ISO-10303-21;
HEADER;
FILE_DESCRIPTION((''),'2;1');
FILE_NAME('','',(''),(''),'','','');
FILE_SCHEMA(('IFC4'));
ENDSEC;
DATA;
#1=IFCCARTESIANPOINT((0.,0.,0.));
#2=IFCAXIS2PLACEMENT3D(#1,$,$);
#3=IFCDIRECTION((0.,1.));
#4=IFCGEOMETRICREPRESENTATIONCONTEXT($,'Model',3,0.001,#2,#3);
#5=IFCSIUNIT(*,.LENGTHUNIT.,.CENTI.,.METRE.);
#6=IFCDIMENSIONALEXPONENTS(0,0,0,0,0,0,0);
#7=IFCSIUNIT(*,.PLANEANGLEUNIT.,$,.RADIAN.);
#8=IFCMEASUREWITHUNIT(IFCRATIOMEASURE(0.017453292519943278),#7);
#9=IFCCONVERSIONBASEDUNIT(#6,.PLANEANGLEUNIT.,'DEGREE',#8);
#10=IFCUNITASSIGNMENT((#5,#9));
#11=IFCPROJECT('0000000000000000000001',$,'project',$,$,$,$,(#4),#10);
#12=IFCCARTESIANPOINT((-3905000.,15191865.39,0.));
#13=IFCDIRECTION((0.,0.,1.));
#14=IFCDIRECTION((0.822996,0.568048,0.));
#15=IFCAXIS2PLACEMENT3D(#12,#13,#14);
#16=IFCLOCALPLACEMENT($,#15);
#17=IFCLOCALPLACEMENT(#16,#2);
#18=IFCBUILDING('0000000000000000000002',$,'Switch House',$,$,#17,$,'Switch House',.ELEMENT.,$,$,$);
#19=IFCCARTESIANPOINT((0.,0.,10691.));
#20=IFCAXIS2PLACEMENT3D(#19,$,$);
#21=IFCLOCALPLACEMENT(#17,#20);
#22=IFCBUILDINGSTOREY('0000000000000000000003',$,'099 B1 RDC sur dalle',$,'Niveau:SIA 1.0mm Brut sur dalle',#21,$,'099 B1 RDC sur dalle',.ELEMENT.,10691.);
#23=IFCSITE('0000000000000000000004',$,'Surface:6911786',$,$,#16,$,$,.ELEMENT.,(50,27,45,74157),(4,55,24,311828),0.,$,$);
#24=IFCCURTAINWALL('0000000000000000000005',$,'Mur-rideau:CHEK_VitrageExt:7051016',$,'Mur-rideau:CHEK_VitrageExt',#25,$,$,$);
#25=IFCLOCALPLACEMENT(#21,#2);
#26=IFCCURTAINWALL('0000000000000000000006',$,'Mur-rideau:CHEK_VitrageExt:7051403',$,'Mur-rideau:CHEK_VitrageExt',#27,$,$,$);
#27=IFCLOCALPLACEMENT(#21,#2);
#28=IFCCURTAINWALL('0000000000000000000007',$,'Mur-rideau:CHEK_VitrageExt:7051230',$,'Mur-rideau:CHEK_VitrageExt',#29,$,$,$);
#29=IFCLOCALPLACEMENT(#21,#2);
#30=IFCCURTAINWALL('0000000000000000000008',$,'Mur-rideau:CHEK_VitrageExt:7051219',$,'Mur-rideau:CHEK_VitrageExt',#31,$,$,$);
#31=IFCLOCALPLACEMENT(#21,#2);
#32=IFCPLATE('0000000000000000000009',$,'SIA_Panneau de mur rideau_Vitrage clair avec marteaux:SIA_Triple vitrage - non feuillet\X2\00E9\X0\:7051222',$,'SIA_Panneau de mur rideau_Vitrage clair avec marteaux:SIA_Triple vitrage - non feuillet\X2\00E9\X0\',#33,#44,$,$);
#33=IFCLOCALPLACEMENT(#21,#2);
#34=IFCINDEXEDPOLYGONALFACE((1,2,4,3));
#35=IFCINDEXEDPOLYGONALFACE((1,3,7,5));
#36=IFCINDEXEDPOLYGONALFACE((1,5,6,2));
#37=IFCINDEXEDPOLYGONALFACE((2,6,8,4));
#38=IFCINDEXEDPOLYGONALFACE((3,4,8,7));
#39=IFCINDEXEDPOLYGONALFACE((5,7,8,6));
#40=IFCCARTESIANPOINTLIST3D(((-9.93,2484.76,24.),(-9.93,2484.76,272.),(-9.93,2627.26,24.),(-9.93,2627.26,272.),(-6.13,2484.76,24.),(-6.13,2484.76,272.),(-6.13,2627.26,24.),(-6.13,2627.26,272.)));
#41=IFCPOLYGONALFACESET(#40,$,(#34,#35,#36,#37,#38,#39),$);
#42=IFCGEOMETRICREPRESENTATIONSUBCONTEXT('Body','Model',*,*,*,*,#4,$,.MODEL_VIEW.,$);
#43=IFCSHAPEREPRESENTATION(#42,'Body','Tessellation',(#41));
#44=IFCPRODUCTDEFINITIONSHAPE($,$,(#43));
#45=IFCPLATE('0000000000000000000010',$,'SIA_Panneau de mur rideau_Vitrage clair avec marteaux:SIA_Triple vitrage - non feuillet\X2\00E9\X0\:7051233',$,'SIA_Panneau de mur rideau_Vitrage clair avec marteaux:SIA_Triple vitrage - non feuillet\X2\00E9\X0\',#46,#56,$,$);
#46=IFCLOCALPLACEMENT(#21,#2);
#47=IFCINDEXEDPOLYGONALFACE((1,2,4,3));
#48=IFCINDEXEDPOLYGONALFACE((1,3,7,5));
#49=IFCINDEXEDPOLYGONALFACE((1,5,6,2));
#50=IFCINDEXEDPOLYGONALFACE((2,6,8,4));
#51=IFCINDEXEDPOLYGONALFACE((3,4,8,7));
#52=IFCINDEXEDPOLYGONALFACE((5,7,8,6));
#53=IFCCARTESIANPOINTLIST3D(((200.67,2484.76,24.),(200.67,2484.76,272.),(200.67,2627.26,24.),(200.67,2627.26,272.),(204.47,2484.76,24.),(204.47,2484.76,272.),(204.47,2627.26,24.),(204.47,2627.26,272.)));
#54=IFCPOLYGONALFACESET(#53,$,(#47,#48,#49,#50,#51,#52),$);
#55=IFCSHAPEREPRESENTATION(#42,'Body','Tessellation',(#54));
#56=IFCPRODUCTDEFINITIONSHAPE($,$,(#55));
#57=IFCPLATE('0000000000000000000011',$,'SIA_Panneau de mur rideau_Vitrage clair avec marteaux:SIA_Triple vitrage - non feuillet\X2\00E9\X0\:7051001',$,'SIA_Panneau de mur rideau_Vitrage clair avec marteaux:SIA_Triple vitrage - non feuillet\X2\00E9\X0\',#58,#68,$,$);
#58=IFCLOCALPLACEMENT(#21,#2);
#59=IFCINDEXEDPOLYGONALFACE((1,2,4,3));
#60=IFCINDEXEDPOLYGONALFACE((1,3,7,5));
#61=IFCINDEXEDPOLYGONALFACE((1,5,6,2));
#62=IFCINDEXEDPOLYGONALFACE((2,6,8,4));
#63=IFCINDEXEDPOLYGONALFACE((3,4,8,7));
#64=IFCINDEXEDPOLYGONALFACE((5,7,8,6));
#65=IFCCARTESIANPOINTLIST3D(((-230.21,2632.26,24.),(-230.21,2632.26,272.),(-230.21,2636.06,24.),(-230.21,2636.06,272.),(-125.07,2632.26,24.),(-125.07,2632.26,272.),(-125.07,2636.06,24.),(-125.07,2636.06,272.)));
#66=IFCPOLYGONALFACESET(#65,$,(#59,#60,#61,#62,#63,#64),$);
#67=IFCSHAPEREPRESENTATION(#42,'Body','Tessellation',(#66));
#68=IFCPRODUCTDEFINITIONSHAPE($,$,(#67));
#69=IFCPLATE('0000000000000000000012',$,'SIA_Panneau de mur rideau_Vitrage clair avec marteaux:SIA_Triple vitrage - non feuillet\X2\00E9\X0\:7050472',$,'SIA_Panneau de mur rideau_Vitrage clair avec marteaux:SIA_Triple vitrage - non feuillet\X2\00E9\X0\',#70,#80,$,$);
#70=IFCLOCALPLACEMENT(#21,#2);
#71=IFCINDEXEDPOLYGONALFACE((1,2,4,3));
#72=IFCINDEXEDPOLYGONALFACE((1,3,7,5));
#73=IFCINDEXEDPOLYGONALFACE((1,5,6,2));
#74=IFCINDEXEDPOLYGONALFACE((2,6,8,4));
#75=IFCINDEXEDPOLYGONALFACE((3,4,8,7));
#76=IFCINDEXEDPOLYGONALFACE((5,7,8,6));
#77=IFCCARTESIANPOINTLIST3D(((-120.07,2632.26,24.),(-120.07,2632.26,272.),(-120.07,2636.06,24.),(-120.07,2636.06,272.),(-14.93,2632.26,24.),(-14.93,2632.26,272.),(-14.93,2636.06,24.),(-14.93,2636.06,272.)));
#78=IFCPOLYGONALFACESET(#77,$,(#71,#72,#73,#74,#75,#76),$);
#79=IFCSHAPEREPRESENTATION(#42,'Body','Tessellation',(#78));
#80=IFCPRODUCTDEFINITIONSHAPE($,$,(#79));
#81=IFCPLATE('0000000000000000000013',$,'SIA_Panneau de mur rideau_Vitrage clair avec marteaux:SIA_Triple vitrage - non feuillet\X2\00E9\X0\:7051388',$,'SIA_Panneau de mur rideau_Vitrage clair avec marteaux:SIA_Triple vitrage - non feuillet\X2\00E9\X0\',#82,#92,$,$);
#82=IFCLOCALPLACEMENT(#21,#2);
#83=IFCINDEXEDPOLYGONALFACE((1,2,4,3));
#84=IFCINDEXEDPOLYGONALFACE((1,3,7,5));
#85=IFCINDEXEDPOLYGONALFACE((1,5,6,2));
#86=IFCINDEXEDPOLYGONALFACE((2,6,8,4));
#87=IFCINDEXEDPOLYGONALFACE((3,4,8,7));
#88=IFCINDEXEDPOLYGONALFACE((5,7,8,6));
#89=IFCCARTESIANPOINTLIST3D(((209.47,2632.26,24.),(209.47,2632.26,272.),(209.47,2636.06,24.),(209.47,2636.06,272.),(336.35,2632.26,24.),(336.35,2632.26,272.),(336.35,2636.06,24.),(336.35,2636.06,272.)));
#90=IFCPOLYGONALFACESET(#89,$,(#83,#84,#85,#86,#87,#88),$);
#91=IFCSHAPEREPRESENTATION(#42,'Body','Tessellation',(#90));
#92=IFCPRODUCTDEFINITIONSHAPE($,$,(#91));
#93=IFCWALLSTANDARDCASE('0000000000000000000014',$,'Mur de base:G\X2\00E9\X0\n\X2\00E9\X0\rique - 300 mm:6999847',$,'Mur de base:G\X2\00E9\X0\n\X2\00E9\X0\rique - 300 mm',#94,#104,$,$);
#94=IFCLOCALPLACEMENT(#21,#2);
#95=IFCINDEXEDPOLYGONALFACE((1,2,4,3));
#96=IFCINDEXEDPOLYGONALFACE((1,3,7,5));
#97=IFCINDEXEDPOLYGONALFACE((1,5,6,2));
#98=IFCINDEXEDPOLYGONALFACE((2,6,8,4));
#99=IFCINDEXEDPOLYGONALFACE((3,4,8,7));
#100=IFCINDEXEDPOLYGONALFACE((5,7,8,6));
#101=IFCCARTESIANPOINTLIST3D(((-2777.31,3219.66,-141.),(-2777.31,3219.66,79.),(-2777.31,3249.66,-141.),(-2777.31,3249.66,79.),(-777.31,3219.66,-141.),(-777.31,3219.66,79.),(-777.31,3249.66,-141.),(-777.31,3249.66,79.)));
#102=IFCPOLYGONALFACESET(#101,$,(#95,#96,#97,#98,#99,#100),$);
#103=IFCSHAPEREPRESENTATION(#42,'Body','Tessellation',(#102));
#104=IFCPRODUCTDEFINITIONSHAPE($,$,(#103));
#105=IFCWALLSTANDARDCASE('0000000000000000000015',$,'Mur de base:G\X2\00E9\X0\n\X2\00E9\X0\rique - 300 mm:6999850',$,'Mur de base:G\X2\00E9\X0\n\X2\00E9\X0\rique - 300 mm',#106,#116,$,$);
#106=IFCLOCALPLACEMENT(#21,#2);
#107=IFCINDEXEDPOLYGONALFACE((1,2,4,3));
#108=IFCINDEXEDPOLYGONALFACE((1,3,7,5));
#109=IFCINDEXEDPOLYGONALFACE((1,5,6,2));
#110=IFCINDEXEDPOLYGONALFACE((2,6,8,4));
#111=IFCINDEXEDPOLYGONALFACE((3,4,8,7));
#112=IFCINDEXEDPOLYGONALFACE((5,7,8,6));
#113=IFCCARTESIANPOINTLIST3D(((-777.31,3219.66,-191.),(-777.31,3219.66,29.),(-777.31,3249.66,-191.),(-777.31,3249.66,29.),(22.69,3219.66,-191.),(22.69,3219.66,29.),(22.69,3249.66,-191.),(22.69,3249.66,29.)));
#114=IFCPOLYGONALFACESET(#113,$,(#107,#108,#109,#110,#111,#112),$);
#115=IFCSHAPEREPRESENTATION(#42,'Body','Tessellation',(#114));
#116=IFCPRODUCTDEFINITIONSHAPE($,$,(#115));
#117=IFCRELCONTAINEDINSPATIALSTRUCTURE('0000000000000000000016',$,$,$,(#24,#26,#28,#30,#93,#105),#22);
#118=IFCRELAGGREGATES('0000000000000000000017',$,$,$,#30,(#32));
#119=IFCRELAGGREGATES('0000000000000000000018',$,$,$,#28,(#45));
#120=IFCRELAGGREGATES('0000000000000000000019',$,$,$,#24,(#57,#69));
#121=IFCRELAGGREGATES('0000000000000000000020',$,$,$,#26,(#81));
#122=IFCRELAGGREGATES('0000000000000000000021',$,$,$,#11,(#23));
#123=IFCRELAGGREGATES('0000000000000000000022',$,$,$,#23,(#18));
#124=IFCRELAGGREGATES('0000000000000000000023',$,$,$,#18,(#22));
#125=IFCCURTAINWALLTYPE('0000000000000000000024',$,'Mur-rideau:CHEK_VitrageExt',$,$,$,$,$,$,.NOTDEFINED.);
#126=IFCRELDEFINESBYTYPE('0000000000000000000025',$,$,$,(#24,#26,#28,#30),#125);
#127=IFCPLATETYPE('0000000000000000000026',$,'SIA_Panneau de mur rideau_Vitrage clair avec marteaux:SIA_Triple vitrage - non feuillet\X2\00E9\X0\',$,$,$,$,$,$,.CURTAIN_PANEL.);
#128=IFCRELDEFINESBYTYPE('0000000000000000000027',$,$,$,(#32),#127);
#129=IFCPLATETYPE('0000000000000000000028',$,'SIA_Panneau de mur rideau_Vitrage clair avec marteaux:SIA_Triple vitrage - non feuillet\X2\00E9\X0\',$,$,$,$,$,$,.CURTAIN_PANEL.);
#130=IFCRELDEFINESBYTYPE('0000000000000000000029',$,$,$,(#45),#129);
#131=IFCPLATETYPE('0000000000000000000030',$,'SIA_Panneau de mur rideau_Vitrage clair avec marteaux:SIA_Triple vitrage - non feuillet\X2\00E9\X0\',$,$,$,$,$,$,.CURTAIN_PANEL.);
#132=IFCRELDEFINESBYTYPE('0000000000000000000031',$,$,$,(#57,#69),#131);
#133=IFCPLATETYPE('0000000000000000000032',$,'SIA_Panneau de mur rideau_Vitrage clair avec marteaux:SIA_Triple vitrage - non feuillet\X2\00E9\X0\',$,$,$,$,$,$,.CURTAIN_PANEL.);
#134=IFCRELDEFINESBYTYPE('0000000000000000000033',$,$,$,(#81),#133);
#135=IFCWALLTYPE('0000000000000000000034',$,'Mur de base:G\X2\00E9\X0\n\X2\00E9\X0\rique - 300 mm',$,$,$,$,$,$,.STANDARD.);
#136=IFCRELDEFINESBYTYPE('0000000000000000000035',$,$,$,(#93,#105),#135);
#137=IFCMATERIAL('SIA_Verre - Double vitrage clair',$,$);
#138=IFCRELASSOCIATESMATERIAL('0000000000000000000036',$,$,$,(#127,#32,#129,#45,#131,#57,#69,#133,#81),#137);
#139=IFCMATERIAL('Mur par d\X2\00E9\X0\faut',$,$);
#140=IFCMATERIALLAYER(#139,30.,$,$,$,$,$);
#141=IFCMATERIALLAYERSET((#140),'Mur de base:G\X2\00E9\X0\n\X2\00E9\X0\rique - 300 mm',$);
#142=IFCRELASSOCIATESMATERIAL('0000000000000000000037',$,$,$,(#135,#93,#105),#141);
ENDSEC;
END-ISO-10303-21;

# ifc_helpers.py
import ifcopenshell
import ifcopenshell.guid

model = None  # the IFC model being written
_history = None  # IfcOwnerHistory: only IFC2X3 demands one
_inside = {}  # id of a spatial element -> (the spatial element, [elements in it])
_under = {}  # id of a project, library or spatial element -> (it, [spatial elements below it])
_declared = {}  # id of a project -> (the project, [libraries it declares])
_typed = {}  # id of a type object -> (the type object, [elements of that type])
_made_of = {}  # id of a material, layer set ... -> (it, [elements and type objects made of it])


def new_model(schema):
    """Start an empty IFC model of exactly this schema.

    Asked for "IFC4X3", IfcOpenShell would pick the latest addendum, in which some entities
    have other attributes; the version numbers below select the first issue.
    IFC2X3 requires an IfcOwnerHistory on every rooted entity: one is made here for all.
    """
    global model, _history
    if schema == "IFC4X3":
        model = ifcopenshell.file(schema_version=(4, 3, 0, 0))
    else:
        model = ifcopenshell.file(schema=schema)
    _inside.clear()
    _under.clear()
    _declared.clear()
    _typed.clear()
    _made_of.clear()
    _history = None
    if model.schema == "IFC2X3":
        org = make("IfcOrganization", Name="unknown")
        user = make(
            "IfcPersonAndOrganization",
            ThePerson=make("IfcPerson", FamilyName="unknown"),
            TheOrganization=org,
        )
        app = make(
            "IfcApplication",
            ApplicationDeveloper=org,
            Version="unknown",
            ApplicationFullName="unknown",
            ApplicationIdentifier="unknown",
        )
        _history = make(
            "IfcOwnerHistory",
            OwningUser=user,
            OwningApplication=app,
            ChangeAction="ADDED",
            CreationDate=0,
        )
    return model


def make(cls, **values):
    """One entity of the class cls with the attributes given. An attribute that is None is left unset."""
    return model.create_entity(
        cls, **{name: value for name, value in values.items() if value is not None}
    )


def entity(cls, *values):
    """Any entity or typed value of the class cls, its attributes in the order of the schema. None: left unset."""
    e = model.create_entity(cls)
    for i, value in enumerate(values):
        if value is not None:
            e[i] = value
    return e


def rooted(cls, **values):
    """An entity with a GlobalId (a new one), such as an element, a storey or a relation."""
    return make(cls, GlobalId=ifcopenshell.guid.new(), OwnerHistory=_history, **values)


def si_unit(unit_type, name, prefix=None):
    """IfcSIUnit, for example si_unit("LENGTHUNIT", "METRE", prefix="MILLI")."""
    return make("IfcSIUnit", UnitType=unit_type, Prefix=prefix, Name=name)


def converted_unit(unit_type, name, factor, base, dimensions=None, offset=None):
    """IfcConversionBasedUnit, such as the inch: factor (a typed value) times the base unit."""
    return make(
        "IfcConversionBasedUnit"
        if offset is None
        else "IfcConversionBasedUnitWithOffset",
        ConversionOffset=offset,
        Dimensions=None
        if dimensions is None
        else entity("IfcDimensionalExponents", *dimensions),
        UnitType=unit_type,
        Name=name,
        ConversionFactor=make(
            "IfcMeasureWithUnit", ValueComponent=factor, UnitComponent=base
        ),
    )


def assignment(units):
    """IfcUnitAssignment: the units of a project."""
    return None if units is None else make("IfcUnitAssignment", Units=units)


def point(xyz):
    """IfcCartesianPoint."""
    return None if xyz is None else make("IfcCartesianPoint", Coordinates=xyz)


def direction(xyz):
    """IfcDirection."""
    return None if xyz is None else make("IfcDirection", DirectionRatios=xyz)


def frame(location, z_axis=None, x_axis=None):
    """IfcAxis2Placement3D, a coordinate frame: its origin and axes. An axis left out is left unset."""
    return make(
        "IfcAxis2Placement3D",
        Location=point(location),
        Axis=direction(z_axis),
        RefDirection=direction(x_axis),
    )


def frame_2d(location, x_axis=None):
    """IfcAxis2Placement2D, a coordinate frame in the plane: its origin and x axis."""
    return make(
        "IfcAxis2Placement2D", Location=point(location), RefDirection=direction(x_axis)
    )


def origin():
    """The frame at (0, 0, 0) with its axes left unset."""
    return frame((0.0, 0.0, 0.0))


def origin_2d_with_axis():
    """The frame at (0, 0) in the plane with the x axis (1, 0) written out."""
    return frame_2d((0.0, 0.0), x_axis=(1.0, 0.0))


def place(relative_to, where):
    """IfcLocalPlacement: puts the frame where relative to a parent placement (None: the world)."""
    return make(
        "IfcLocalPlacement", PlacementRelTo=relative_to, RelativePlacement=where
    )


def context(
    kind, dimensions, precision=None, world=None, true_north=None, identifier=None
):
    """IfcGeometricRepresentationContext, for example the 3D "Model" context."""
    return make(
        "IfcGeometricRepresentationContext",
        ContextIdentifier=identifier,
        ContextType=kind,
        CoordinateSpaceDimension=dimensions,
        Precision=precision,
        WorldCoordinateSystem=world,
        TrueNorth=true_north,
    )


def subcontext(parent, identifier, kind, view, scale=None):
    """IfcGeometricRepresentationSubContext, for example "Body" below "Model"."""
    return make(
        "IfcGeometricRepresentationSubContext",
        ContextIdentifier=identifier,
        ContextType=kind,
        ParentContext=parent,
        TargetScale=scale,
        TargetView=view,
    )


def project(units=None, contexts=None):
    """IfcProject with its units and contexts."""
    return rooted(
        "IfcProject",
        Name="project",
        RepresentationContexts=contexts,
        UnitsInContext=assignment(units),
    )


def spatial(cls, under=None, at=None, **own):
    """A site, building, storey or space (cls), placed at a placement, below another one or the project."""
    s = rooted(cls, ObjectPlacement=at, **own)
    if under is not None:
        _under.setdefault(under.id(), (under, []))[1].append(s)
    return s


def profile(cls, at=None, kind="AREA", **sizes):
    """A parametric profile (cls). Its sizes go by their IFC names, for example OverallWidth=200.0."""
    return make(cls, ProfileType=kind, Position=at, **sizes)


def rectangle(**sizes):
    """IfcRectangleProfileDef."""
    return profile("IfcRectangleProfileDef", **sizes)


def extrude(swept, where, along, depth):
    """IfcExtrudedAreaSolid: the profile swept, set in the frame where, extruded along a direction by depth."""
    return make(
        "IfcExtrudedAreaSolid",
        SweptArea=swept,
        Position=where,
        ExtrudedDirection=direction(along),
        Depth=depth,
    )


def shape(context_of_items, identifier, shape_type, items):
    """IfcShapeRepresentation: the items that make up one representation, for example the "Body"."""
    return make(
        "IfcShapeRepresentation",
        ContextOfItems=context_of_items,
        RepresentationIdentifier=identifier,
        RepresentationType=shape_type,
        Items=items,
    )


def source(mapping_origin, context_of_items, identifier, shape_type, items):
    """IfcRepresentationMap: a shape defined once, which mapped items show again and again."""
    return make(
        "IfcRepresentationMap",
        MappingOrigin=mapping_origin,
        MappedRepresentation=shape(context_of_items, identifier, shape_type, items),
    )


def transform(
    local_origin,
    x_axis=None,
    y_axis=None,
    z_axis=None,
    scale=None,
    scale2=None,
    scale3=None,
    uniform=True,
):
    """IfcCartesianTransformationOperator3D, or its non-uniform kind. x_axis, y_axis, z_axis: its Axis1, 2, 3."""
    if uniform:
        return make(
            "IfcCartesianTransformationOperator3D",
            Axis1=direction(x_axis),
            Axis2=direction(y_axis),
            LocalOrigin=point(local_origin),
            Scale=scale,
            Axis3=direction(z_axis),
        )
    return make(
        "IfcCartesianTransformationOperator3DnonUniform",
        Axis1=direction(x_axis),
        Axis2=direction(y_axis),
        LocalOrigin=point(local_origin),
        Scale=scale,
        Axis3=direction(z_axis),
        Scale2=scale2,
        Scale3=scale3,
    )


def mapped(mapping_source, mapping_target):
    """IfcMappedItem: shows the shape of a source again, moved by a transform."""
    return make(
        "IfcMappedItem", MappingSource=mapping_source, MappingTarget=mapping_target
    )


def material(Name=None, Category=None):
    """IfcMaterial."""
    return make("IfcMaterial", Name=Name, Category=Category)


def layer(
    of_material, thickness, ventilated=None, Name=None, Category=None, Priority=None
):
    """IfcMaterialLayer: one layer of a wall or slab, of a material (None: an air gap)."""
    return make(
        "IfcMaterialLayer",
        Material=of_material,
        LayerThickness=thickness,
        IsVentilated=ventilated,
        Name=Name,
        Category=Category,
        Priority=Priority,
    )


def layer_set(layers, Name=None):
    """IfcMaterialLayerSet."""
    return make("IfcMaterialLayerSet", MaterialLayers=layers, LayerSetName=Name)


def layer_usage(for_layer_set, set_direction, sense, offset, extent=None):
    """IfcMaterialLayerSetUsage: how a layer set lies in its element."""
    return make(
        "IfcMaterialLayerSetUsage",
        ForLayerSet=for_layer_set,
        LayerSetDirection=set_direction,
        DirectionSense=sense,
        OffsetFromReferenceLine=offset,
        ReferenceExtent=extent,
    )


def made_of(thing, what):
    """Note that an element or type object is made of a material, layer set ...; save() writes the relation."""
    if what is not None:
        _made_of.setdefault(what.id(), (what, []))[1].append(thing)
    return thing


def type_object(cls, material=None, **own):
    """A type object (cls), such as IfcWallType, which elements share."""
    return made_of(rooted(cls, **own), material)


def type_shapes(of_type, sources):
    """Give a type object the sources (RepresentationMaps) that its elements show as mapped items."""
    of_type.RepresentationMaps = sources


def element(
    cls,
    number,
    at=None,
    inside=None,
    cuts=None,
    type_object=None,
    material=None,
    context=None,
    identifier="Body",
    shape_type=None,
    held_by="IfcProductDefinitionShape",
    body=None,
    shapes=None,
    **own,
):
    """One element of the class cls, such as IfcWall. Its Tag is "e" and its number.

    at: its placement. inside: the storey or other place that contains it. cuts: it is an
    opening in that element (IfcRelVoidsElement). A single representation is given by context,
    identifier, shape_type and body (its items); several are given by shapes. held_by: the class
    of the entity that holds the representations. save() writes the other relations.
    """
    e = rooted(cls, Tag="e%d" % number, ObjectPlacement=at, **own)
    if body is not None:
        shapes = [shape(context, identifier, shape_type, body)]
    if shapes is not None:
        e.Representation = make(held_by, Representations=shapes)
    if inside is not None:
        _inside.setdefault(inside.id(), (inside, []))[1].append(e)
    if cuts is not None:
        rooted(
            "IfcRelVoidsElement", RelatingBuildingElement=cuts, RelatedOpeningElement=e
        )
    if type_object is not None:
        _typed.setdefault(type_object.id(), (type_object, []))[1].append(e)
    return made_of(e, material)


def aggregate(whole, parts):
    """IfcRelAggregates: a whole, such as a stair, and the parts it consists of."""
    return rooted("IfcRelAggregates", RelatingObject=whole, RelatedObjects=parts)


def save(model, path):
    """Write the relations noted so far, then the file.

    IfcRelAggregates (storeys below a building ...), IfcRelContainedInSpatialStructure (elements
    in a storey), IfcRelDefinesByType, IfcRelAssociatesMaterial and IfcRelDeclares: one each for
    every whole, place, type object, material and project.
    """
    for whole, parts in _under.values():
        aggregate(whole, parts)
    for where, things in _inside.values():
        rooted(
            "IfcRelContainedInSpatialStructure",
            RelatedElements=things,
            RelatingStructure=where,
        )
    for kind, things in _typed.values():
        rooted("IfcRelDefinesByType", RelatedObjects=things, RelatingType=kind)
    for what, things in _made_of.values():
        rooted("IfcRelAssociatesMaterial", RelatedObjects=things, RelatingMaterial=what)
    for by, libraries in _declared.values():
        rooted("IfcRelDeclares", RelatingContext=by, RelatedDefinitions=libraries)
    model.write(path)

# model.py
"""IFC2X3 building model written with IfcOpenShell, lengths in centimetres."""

from ifc_helpers import new_model, entity, si_unit, converted_unit, direction, frame, frame_2d, origin, origin_2d_with_axis, place, context, subcontext, project, spatial, rectangle, extrude, source, transform, mapped, material, layer, layer_set, layer_usage, type_object, type_shapes, element, aggregate, save


model = new_model("IFC2X3")

# Units and contexts
model_context = context("Model", 3, precision=0.001, world=origin(), true_north=direction((0.0, 1.0)))
body_context = subcontext(model_context, "Body", "Model", "MODEL_VIEW")
ifc_project = project(units=[si_unit("LENGTHUNIT", "METRE", prefix="CENTI"), converted_unit("PLANEANGLEUNIT", "DEGREE", entity("IfcRatioMeasure", 0.017453292519943278), si_unit("PLANEANGLEUNIT", "RADIAN"), dimensions=[0, 0, 0, 0, 0, 0, 0])], contexts=[model_context])

# Site, building, storey
site_placement = place(None, frame((-3905000.0, 15191865.39, 0.0), z_axis=(0.0, 0.0, 1.0), x_axis=(0.822996, 0.568048, 0.0)))
site = spatial("IfcSite", under=ifc_project, at=site_placement, Name="Surface:6911786", CompositionType="ELEMENT", RefLatitude=(50, 27, 45, 74157), RefLongitude=(4, 55, 24, 311828), RefElevation=0.0)
building_placement = place(site_placement, origin())
building = spatial("IfcBuilding", under=site, at=building_placement, Name="Switch House", LongName="Switch House", CompositionType="ELEMENT")
storey_placement = place(building_placement, frame((0.0, 0.0, 10691.0)))
storey = spatial("IfcBuildingStorey", under=building, at=storey_placement, Name="099 B1 RDC sur dalle", ObjectType="Niveau:SIA 1.0mm Brut sur dalle", LongName="099 B1 RDC sur dalle", CompositionType="ELEMENT", Elevation=10691.0)

# Curtain walls
curtain_wall_type = type_object("IfcCurtainWallType", Name="Mur-rideau:CHEK_VitrageExt", PredefinedType="NOTDEFINED")
curtain_wall_1_placement = place(storey_placement, frame((0.0, 0.0, -10691.0)))
curtain_wall_1 = element("IfcCurtainWall", 1, at=curtain_wall_1_placement, inside=storey, type_object=curtain_wall_type, Name="Mur-rideau:CHEK_VitrageExt:7051016", ObjectType="Mur-rideau:CHEK_VitrageExt")
curtain_wall_2_placement = place(storey_placement, frame((0.0, 0.0, -10691.0)))
curtain_wall_2 = element("IfcCurtainWall", 2, at=curtain_wall_2_placement, inside=storey, type_object=curtain_wall_type, Name="Mur-rideau:CHEK_VitrageExt:7051403", ObjectType="Mur-rideau:CHEK_VitrageExt")

# Curtain wall
curtain_wall_3_placement = place(storey_placement, frame((0.0, 0.0, -10691.0)))
curtain_wall_3 = element("IfcCurtainWall", 3, at=curtain_wall_3_placement, inside=storey, type_object=curtain_wall_type, Name="Mur-rideau:CHEK_VitrageExt:7051230", ObjectType="Mur-rideau:CHEK_VitrageExt")

# Curtain wall
curtain_wall_4_placement = place(storey_placement, frame((0.0, 0.0, -10691.0)))
curtain_wall_4 = element("IfcCurtainWall", 4, at=curtain_wall_4_placement, inside=storey, type_object=curtain_wall_type, Name="Mur-rideau:CHEK_VitrageExt:7051219", ObjectType="Mur-rideau:CHEK_VitrageExt")

# Plates
ifc_material_1 = material(Name="SIA_Verre - Double vitrage clair")
plate_type_1 = type_object("IfcPlateType", Name="SIA_Panneau de mur rideau_Vitrage clair avec marteaux:SIA_Triple vitrage - non feuilleté", PredefinedType="CURTAIN_PANEL", material=ifc_material_1)
shared_shape_1 = source(origin(), body_context, "Body", "SweptSolid", [
    extrude(rectangle(XDim=3.8, YDim=142.5, at=origin_2d_with_axis()), frame((0.0, -1.9, 0.0), z_axis=(0.0, 0.0, 1.0), x_axis=(0.0, 1.0, 0.0)), (0.0, 0.0, 1.0), 248.0),
])
type_shapes(plate_type_1, [shared_shape_1])
plate_1_placement = place(curtain_wall_4_placement, frame((-9.93, 2556.01, 10715.0), z_axis=(0.0, 0.0, 1.0), x_axis=(0.0, 1.0, 0.0)))
plate_1 = element("IfcPlate", 5, at=plate_1_placement, type_object=plate_type_1, material=ifc_material_1, Name="SIA_Panneau de mur rideau_Vitrage clair avec marteaux:SIA_Triple vitrage - non feuilleté:7051222", ObjectType="SIA_Panneau de mur rideau_Vitrage clair avec marteaux:SIA_Triple vitrage - non feuilleté", context=body_context, shape_type="MappedRepresentation", body=[
    mapped(shared_shape_1, transform((0.0, 0.0, 0.0), scale=1.0)),
])
aggregate(curtain_wall_4, [plate_1])
plate_type_2 = type_object("IfcPlateType", Name="SIA_Panneau de mur rideau_Vitrage clair avec marteaux:SIA_Triple vitrage - non feuilleté", PredefinedType="CURTAIN_PANEL", material=ifc_material_1)
shared_shape_2 = source(origin(), body_context, "Body", "SweptSolid", [
    extrude(rectangle(XDim=142.5, YDim=3.8, at=origin_2d_with_axis()), frame((0.0, 1.9, 0.0), z_axis=(0.0, 0.0, 1.0), x_axis=(-1.0, 0.0, 0.0)), (0.0, 0.0, 1.0), 248.0),
])
type_shapes(plate_type_2, [shared_shape_2])
plate_2_placement = place(curtain_wall_3_placement, frame((204.47, 2556.01, 10715.0), z_axis=(0.0, 0.0, 1.0), x_axis=(0.0, 1.0, 0.0)))
plate_2 = element("IfcPlate", 6, at=plate_2_placement, type_object=plate_type_2, material=ifc_material_1, Name="SIA_Panneau de mur rideau_Vitrage clair avec marteaux:SIA_Triple vitrage - non feuilleté:7051233", ObjectType="SIA_Panneau de mur rideau_Vitrage clair avec marteaux:SIA_Triple vitrage - non feuilleté", context=body_context, shape_type="MappedRepresentation", body=[
    mapped(shared_shape_2, transform((0.0, 0.0, 0.0), scale=1.0)),
])
aggregate(curtain_wall_3, [plate_2])
plate_type_3 = type_object("IfcPlateType", Name="SIA_Panneau de mur rideau_Vitrage clair avec marteaux:SIA_Triple vitrage - non feuilleté", PredefinedType="CURTAIN_PANEL", material=ifc_material_1)
shared_shape_3 = source(origin(), body_context, "Body", "SweptSolid", [
    extrude(rectangle(XDim=105.14, YDim=3.8, at=origin_2d_with_axis()), frame((0.0, 1.9, 0.0), z_axis=(0.0, 0.0, 1.0), x_axis=(-1.0, 0.0, 0.0)), (0.0, 0.0, 1.0), 248.0),
])
type_shapes(plate_type_3, [shared_shape_3])
plate_3_placement = place(curtain_wall_1_placement, frame((-177.64, 2632.26, 10715.0)))
plate_3 = element("IfcPlate", 7, at=plate_3_placement, type_object=plate_type_3, material=ifc_material_1, Name="SIA_Panneau de mur rideau_Vitrage clair avec marteaux:SIA_Triple vitrage - non feuilleté:7051001", ObjectType="SIA_Panneau de mur rideau_Vitrage clair avec marteaux:SIA_Triple vitrage - non feuilleté", context=body_context, shape_type="MappedRepresentation", body=[
    mapped(shared_shape_3, transform((0.0, 0.0, 0.0), scale=1.0)),
])
plate_4_placement = place(curtain_wall_1_placement, frame((-67.5, 2632.26, 10715.0)))
plate_4 = element("IfcPlate", 8, at=plate_4_placement, type_object=plate_type_3, material=ifc_material_1, Name="SIA_Panneau de mur rideau_Vitrage clair avec marteaux:SIA_Triple vitrage - non feuilleté:7050472", ObjectType="SIA_Panneau de mur rideau_Vitrage clair avec marteaux:SIA_Triple vitrage - non feuilleté", context=body_context, shape_type="MappedRepresentation", body=[
    mapped(shared_shape_3, transform((0.0, 0.0, 0.0), scale=1.0)),
])
aggregate(curtain_wall_1, [plate_3, plate_4])
plate_type_4 = type_object("IfcPlateType", Name="SIA_Panneau de mur rideau_Vitrage clair avec marteaux:SIA_Triple vitrage - non feuilleté", PredefinedType="CURTAIN_PANEL", material=ifc_material_1)
shared_shape_4 = source(origin(), body_context, "Body", "SweptSolid", [
    extrude(rectangle(XDim=126.88, YDim=3.8, at=origin_2d_with_axis()), frame((0.0, 1.9, 0.0), z_axis=(0.0, 0.0, 1.0), x_axis=(-1.0, 0.0, 0.0)), (0.0, 0.0, 1.0), 248.0),
])
type_shapes(plate_type_4, [shared_shape_4])
plate_5_placement = place(curtain_wall_2_placement, frame((272.91, 2632.26, 10715.0)))
plate_5 = element("IfcPlate", 9, at=plate_5_placement, type_object=plate_type_4, material=ifc_material_1, Name="SIA_Panneau de mur rideau_Vitrage clair avec marteaux:SIA_Triple vitrage - non feuilleté:7051388", ObjectType="SIA_Panneau de mur rideau_Vitrage clair avec marteaux:SIA_Triple vitrage - non feuilleté", context=body_context, shape_type="MappedRepresentation", body=[
    mapped(shared_shape_4, transform((0.0, 0.0, 0.0), scale=1.0)),
])
aggregate(curtain_wall_2, [plate_5])

# Walls
ifc_material_2 = material(Name="Mur par défaut")
ifc_layer = layer(ifc_material_2, 30.0)
ifc_layer_set = layer_set([ifc_layer], Name="Mur de base:Générique - 300 mm")
ifc_layer_usage_1 = layer_usage(ifc_layer_set, "AXIS2", "POSITIVE", -15.0)
wall_type = type_object("IfcWallType", Name="Mur de base:Générique - 300 mm", PredefinedType="STANDARD", material=ifc_layer_set)
wall_1_placement = place(storey_placement, frame((-777.31, 3234.66, -141.0), z_axis=(0.0, 0.0, 1.0), x_axis=(-1.0, 0.0, 0.0)))
element("IfcWallStandardCase", 10, at=wall_1_placement, inside=storey, type_object=wall_type, material=ifc_layer_usage_1, Name="Mur de base:Générique - 300 mm:6999847", ObjectType="Mur de base:Générique - 300 mm", context=body_context, shape_type="SweptSolid", body=[
    extrude(rectangle(XDim=2000.0, YDim=30.0, at=frame_2d((1000.0, 0.0), x_axis=(-1.0, 0.0))), origin(), (0.0, 0.0, 1.0), 220.0),
])
ifc_layer_usage_2 = layer_usage(ifc_layer_set, "AXIS2", "NEGATIVE", 15.0)
wall_2_placement = place(storey_placement, frame((22.69, 3234.66, -191.0), z_axis=(0.0, 0.0, 1.0), x_axis=(-1.0, 0.0, 0.0)))
element("IfcWallStandardCase", 11, at=wall_2_placement, inside=storey, type_object=wall_type, material=ifc_layer_usage_2, Name="Mur de base:Générique - 300 mm:6999850", ObjectType="Mur de base:Générique - 300 mm", context=body_context, shape_type="SweptSolid", body=[
    extrude(rectangle(XDim=800.0, YDim=30.0, at=frame_2d((400.0, 0.0), x_axis=(-1.0, 0.0))), origin(), (0.0, 0.0, 1.0), 220.0),
])

save(model, "model.ifc")
